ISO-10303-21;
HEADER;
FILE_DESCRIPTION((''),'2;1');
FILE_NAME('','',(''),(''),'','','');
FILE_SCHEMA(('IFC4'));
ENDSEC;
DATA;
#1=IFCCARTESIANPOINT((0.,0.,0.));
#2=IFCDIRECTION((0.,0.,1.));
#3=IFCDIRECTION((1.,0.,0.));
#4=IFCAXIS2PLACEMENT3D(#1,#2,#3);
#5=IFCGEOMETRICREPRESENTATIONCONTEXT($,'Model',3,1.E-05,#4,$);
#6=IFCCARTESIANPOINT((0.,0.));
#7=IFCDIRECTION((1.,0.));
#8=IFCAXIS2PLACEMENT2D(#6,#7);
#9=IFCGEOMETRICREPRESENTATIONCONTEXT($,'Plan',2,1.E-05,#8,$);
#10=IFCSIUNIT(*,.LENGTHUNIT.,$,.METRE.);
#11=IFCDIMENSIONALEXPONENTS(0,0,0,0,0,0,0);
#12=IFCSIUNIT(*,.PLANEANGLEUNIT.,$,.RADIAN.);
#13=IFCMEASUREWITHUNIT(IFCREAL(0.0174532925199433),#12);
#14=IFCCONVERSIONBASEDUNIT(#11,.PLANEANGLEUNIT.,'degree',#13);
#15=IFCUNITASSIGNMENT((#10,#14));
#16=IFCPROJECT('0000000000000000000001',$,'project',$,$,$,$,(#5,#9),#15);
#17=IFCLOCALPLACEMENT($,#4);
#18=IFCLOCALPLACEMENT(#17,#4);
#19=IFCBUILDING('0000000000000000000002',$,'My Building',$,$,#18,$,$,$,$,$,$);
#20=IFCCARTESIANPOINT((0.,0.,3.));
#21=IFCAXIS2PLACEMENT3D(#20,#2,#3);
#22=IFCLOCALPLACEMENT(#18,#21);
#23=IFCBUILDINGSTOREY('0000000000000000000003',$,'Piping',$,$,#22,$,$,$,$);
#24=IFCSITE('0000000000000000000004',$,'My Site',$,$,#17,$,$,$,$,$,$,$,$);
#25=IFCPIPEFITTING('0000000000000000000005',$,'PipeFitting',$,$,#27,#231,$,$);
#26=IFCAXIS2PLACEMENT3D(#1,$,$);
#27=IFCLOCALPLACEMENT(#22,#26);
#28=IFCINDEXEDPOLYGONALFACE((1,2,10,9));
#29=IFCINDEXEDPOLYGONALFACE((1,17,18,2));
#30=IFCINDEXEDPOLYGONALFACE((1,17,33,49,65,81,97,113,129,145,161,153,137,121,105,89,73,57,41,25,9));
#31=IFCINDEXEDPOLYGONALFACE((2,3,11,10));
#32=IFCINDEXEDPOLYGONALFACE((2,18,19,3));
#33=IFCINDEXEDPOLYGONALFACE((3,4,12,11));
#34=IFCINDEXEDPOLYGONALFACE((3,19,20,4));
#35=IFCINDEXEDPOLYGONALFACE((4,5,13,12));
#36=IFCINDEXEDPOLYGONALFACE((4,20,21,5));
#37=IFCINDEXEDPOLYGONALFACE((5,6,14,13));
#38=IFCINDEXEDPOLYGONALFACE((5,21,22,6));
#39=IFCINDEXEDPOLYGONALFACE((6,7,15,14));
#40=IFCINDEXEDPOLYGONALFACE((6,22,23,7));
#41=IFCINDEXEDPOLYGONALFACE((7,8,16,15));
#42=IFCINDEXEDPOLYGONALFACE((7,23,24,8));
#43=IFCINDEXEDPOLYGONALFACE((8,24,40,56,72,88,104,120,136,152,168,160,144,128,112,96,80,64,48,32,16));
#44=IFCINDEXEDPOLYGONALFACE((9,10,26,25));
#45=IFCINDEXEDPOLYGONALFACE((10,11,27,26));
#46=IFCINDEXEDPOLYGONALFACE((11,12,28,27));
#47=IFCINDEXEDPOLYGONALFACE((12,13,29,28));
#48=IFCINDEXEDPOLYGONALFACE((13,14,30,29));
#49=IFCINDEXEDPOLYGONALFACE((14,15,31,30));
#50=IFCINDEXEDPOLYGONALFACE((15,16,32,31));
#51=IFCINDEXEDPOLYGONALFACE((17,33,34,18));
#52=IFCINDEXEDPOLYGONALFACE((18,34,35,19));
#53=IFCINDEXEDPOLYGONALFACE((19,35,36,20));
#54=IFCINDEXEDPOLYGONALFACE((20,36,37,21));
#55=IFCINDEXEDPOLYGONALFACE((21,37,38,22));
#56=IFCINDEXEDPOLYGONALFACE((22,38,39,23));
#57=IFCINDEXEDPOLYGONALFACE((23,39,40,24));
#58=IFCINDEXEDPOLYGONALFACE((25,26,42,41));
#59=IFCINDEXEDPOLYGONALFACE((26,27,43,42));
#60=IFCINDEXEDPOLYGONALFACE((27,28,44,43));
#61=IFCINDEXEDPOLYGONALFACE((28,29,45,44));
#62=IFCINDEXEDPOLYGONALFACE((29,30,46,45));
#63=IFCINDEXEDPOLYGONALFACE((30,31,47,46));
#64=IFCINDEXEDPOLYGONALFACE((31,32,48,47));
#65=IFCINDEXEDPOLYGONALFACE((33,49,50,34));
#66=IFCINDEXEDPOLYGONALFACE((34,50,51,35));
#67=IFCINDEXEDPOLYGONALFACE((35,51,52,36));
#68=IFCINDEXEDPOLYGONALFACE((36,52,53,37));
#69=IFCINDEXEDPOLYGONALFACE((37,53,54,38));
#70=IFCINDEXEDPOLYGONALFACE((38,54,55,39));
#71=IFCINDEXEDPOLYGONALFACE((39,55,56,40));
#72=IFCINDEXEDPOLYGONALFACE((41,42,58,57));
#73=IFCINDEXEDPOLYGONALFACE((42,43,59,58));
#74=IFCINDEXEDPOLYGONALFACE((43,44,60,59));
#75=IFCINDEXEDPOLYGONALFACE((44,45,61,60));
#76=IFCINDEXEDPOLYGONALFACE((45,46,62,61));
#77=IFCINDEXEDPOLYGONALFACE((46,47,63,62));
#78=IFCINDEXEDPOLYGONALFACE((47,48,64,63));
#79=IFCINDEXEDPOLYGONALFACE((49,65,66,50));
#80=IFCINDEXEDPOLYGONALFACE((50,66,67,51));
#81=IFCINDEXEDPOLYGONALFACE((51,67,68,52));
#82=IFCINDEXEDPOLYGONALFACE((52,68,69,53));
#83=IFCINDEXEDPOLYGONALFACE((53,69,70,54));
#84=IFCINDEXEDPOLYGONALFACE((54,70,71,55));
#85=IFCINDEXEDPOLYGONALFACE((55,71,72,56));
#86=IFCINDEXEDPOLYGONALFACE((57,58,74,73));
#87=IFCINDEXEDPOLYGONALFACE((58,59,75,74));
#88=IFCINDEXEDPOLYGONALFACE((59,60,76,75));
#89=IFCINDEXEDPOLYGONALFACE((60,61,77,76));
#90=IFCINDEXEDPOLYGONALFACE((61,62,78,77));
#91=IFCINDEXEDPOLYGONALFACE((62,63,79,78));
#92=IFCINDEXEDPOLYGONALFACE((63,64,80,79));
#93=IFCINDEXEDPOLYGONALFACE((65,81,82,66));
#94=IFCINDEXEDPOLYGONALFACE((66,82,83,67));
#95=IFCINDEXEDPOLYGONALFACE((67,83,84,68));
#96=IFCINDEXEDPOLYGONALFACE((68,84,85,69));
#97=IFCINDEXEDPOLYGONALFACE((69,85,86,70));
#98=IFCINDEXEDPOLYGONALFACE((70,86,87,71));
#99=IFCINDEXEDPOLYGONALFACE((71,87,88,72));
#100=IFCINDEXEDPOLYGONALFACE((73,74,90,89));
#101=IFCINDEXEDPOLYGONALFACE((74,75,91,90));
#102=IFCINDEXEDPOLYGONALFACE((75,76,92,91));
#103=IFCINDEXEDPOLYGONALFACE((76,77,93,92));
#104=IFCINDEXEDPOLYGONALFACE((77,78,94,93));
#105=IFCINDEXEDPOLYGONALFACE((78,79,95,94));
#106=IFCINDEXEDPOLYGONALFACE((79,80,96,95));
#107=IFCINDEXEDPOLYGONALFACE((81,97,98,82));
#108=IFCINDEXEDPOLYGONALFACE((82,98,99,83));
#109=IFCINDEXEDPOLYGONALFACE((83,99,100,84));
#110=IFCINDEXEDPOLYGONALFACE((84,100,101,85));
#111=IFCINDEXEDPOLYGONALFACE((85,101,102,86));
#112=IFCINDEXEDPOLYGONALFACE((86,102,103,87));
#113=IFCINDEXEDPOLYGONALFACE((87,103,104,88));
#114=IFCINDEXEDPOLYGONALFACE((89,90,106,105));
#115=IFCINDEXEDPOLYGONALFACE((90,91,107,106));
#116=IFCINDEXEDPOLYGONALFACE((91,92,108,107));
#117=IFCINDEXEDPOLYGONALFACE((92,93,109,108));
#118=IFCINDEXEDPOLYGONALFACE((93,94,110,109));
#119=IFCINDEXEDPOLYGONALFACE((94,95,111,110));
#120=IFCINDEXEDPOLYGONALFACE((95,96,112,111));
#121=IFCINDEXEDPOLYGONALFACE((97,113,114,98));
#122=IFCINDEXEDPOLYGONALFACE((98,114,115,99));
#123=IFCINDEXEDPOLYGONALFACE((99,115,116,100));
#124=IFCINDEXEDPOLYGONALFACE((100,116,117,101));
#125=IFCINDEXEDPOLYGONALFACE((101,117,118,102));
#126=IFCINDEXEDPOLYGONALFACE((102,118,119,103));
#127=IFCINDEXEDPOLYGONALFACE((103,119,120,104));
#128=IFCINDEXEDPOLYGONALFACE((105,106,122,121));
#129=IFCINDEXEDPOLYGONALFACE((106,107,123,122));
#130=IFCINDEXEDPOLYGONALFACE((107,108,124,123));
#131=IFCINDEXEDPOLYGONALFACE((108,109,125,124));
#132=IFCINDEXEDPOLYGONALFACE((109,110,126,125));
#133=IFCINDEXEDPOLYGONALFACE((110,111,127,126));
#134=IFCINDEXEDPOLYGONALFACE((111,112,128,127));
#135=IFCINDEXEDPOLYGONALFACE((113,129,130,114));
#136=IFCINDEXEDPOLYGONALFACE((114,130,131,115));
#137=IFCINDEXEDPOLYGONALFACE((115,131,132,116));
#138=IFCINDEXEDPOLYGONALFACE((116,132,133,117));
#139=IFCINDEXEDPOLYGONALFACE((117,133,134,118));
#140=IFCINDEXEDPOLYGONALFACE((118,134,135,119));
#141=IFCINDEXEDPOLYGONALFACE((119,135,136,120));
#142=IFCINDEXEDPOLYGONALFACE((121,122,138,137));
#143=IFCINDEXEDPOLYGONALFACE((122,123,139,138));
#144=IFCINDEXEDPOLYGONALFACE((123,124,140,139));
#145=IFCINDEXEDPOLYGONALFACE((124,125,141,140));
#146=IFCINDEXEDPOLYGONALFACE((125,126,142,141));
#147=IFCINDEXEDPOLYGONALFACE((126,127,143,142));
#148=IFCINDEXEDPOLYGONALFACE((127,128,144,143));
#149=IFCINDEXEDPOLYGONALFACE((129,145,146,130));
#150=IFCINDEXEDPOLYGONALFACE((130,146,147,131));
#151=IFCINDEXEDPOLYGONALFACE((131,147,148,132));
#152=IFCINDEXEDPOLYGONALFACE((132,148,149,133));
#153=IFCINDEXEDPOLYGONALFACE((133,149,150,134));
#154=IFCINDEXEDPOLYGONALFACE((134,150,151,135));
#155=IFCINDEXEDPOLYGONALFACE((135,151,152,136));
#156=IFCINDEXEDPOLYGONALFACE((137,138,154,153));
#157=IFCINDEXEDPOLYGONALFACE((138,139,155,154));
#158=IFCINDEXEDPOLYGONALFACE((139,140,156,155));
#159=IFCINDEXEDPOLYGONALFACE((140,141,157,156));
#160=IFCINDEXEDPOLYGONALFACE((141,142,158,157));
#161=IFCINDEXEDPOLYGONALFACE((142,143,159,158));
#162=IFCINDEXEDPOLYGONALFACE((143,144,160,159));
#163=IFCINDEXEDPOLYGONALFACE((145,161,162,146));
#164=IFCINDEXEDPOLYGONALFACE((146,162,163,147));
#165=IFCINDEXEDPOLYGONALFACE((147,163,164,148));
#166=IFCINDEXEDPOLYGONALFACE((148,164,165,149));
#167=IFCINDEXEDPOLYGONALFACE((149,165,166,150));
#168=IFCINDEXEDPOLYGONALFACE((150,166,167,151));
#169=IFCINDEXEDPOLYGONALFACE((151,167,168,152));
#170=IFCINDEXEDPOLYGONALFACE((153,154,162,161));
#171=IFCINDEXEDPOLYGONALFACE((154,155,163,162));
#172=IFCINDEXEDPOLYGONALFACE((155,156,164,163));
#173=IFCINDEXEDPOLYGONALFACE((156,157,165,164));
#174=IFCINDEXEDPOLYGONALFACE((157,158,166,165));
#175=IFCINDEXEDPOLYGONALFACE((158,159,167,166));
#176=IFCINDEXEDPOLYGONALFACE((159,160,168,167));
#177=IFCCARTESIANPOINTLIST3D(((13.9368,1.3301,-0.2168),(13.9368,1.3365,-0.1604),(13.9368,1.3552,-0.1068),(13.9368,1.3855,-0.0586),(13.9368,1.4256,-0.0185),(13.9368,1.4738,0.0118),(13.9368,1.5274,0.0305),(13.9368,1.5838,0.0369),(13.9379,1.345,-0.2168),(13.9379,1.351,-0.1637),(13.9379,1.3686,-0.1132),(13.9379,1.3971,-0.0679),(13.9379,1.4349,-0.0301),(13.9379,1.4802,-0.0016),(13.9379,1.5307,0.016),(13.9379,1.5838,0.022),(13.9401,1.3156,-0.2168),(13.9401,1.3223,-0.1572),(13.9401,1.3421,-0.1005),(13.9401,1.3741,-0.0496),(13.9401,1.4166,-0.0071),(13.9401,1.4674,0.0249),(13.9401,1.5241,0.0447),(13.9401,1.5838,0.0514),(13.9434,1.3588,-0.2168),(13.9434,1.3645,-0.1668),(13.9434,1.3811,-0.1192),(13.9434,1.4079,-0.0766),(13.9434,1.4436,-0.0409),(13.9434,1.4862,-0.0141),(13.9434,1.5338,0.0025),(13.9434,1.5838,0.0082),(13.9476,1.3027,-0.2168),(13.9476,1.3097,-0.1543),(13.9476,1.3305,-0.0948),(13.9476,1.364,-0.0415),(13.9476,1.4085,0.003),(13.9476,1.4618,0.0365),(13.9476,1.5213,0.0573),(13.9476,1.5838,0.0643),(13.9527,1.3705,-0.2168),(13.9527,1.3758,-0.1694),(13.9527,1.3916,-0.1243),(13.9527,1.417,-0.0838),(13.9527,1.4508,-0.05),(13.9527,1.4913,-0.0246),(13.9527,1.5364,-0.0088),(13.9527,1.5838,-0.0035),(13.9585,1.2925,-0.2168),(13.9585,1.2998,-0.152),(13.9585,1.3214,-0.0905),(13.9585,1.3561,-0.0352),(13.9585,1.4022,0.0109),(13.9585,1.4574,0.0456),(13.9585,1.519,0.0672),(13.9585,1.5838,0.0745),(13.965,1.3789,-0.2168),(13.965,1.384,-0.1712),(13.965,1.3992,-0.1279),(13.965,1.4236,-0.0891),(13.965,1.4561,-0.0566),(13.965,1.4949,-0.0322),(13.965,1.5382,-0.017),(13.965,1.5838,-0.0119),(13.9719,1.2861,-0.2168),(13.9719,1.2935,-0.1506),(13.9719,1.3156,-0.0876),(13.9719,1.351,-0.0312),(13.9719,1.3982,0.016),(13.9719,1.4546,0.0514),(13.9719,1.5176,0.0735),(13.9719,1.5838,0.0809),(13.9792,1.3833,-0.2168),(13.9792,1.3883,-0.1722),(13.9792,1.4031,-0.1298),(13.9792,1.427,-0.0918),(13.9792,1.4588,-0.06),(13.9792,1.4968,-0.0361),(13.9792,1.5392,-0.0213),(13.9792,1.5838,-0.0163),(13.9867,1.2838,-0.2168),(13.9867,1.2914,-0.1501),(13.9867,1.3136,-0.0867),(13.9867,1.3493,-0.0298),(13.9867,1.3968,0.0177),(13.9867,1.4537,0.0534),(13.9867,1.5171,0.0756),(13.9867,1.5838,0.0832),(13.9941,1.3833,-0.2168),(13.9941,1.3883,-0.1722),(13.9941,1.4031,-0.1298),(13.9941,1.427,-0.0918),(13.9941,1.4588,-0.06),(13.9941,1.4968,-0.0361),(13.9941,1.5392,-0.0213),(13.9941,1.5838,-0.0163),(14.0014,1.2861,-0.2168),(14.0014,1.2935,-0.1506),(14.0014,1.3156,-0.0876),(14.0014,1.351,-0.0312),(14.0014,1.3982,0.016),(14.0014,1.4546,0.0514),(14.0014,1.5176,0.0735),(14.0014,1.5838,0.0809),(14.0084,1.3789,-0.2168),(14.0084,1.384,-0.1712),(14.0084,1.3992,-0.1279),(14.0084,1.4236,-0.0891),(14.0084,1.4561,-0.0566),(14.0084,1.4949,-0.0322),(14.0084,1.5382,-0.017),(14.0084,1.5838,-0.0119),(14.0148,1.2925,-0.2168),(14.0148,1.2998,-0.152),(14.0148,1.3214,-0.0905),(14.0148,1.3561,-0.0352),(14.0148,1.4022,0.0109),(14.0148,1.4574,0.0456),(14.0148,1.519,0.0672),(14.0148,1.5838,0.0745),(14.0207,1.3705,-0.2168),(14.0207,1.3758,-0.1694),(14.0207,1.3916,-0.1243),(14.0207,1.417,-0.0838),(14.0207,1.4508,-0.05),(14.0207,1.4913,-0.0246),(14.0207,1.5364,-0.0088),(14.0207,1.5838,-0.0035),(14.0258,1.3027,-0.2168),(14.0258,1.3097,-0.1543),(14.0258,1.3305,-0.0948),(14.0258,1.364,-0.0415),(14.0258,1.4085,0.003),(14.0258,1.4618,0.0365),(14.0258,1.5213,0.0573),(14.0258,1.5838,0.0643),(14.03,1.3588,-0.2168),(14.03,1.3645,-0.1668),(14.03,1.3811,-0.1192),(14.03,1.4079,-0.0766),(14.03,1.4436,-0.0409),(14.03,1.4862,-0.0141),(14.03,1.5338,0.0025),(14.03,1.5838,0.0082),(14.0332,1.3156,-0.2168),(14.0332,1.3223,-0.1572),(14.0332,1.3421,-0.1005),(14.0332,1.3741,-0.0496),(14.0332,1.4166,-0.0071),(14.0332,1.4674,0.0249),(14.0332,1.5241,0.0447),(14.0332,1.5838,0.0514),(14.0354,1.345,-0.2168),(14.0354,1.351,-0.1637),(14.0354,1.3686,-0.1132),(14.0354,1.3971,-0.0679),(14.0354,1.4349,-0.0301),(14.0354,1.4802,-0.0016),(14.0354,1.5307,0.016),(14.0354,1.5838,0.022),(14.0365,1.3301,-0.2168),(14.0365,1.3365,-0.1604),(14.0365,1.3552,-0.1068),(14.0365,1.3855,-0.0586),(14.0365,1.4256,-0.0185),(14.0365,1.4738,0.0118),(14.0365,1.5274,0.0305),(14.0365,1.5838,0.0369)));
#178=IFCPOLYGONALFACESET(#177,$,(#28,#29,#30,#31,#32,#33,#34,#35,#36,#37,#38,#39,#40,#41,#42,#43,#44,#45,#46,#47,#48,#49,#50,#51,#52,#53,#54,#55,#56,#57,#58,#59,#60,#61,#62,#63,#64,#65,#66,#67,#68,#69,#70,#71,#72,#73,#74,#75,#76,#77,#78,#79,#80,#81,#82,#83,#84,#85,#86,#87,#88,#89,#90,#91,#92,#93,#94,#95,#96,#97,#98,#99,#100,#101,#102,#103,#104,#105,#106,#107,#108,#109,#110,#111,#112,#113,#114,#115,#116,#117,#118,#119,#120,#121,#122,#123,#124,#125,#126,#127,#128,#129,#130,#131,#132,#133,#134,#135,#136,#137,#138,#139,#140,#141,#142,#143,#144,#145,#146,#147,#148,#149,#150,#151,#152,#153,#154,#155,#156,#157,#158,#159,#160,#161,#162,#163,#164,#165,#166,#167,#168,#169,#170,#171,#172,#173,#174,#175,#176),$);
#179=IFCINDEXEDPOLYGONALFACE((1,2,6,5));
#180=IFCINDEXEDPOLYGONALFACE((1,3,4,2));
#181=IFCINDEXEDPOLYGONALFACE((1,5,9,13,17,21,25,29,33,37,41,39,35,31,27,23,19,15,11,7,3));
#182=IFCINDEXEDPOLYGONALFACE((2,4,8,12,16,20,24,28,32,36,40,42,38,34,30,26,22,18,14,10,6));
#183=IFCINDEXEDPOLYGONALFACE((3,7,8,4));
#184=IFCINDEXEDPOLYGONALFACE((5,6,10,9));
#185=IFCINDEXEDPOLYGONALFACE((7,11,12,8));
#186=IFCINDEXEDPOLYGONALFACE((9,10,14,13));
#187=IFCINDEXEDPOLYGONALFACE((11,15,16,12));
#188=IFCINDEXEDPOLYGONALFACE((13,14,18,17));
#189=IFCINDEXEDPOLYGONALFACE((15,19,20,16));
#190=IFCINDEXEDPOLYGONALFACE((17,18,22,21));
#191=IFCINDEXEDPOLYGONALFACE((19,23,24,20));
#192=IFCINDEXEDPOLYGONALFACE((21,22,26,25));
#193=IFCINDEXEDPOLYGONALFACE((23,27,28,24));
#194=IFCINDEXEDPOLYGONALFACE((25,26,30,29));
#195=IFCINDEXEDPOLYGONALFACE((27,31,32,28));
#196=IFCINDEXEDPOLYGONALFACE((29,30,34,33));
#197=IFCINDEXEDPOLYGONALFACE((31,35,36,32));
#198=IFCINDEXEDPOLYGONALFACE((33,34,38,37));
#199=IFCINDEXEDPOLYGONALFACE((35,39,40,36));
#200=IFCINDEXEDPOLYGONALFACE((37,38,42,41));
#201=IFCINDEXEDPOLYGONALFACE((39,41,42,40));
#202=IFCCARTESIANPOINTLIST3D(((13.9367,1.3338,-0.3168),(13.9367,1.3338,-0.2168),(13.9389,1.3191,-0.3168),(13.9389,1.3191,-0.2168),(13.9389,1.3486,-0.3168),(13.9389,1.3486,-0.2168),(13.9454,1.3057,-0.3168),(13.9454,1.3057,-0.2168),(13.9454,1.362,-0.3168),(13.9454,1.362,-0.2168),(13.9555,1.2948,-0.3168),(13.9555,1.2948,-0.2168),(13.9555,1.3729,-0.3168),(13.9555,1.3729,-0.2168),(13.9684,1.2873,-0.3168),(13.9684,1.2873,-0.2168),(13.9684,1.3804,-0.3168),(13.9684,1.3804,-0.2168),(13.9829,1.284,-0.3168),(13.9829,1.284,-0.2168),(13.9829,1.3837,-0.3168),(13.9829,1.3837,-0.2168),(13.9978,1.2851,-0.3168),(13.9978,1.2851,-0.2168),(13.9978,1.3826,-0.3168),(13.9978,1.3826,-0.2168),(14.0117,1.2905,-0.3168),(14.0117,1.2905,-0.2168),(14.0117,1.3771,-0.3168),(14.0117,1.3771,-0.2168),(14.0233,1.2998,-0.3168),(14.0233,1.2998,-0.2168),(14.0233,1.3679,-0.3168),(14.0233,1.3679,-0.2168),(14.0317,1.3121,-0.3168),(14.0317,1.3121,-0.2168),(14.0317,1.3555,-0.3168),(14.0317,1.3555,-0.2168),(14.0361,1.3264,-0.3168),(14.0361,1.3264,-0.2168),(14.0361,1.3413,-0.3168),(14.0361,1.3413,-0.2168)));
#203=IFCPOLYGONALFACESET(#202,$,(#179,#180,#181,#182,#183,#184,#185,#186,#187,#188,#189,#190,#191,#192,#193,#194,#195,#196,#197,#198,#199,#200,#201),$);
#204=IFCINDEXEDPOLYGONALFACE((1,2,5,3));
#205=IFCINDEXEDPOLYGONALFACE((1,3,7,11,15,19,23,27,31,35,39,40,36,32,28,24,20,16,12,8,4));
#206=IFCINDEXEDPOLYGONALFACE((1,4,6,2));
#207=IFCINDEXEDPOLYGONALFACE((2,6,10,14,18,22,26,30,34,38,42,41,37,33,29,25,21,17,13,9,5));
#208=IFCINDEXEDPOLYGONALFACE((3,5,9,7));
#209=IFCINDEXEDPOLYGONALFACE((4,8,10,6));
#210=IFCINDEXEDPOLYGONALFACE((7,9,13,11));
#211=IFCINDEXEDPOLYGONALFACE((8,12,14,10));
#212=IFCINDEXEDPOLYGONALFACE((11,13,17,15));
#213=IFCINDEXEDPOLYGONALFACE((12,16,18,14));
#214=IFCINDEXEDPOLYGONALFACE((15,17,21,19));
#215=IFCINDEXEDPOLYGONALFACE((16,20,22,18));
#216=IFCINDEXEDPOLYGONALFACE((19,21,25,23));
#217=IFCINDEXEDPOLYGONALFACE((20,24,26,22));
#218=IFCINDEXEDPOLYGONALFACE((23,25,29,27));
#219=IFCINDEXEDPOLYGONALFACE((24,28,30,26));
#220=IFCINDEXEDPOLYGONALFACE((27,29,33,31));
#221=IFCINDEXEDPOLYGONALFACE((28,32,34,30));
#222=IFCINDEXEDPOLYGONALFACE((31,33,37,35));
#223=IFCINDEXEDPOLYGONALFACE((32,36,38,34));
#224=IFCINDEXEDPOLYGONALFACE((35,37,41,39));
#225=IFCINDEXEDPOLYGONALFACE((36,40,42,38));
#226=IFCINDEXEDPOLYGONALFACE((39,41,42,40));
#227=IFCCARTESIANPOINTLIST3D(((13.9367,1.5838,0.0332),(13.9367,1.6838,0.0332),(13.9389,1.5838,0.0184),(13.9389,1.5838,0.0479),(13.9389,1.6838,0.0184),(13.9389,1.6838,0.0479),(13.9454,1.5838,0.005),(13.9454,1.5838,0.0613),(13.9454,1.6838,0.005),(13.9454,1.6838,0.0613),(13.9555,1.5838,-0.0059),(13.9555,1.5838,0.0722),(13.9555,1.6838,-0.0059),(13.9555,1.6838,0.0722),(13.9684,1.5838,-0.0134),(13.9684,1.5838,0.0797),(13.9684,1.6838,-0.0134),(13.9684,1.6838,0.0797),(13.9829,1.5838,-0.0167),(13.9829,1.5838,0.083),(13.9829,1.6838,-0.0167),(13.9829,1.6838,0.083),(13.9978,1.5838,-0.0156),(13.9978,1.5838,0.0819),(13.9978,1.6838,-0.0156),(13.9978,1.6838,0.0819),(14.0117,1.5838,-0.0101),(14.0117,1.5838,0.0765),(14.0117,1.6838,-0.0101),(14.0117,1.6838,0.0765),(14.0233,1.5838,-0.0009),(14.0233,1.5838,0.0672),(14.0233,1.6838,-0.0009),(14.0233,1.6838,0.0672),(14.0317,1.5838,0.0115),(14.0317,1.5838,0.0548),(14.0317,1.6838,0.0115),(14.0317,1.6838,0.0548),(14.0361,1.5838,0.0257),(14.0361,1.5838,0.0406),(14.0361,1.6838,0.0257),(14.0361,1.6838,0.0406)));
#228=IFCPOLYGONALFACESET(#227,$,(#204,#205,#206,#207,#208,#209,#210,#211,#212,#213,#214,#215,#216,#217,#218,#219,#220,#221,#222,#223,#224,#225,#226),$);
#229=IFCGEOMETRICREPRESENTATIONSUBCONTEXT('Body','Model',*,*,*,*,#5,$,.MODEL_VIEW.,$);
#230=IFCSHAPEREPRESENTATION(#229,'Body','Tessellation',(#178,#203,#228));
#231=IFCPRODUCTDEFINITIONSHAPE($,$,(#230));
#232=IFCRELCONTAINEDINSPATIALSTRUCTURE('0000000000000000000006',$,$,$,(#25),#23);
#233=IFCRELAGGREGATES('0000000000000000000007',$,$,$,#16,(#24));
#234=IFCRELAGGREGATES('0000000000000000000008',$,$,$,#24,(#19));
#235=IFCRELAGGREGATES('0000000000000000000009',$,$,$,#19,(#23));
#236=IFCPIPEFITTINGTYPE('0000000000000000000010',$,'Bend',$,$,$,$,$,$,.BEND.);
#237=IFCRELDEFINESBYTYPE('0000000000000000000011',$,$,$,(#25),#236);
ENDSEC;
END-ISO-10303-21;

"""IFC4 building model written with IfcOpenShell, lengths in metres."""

from ifc_helpers import new_model, entity, si_unit, converted_unit, frame, origin_with_axes, origin_2d_with_axis, place, context, subcontext, project, spatial, circle, extrude, source, transform, mapped, type_object, type_shapes, element, save


model = new_model("IFC4")

# Units and contexts
model_context = context("Model", 3, precision=1e-05, world=origin_with_axes())
plan_context = context("Plan", 2, precision=1e-05, world=origin_2d_with_axis())
body_context = subcontext(model_context, "Body", "Model", "MODEL_VIEW")
ifc_project = project(units=[si_unit("LENGTHUNIT", "METRE"), converted_unit("PLANEANGLEUNIT", "degree", entity("IfcReal", 0.0174532925199433), si_unit("PLANEANGLEUNIT", "RADIAN"), dimensions=[0, 0, 0, 0, 0, 0, 0])], contexts=[model_context, plan_context])

# Site, building, storey
site_placement = place(None, origin_with_axes())
site = spatial("IfcSite", under=ifc_project, at=site_placement, Name="My Site")
building_placement = place(site_placement, origin_with_axes())
building = spatial("IfcBuilding", under=site, at=building_placement, Name="My Building")
storey_placement = place(building_placement, frame((0.0, 0.0, 3.0), z_axis=(0.0, 0.0, 1.0), x_axis=(1.0, 0.0, 0.0)))
storey = spatial("IfcBuildingStorey", under=building, at=storey_placement, Name="Piping")

# Pipe fitting
pipe_fitting_type = type_object("IfcPipeFittingType", Name="Bend", PredefinedType="BEND")
shared_shape = source(origin_with_axes(), body_context, "Body", "SolidModel", [
    entity("IfcSweptDiskSolid", entity("IfcIndexedPolyCurve", entity("IfcCartesianPointList3D", [[0.0, 0.0, -0.1], [0.0, 0.0732, -0.2768], [0.0, 0.25, -0.35]]), [entity("IfcArcIndex", [1, 2, 3])]), 0.05),
    extrude(circle(Radius=0.05), origin_with_axes(), (0.0, 0.0, -1.0), 0.1),
    extrude(circle(Radius=0.05), frame((0.0, 0.25, -0.35), z_axis=(0.0, 1.0, 0.0), x_axis=(1.0, 0.0, 0.0)), (0.0, 0.0, 1.0), 0.1),
])
type_shapes(pipe_fitting_type, [shared_shape])
for number, where, z_axis, x_axis, name in (
    (1, (13.9867, 1.3338, -0.3168), (0.0, 0.0, -1.0), (-1.0, 0.0, 0.0), "PipeFitting"),
):
    element("IfcPipeFitting", number, at=place(storey_placement, frame(where, z_axis=z_axis, x_axis=x_axis)), inside=storey, type_object=pipe_fitting_type, Name=name, context=body_context, shape_type="MappedRepresentation", body=[
        mapped(shared_shape, transform((0.0, 0.0, 0.0), x_axis=(1.0, 0.0, 0.0), y_axis=(0.0, 1.0, 0.0), z_axis=(0.0, 0.0, 1.0), scale=1.0)),
    ])

save(model, "model.ifc")
